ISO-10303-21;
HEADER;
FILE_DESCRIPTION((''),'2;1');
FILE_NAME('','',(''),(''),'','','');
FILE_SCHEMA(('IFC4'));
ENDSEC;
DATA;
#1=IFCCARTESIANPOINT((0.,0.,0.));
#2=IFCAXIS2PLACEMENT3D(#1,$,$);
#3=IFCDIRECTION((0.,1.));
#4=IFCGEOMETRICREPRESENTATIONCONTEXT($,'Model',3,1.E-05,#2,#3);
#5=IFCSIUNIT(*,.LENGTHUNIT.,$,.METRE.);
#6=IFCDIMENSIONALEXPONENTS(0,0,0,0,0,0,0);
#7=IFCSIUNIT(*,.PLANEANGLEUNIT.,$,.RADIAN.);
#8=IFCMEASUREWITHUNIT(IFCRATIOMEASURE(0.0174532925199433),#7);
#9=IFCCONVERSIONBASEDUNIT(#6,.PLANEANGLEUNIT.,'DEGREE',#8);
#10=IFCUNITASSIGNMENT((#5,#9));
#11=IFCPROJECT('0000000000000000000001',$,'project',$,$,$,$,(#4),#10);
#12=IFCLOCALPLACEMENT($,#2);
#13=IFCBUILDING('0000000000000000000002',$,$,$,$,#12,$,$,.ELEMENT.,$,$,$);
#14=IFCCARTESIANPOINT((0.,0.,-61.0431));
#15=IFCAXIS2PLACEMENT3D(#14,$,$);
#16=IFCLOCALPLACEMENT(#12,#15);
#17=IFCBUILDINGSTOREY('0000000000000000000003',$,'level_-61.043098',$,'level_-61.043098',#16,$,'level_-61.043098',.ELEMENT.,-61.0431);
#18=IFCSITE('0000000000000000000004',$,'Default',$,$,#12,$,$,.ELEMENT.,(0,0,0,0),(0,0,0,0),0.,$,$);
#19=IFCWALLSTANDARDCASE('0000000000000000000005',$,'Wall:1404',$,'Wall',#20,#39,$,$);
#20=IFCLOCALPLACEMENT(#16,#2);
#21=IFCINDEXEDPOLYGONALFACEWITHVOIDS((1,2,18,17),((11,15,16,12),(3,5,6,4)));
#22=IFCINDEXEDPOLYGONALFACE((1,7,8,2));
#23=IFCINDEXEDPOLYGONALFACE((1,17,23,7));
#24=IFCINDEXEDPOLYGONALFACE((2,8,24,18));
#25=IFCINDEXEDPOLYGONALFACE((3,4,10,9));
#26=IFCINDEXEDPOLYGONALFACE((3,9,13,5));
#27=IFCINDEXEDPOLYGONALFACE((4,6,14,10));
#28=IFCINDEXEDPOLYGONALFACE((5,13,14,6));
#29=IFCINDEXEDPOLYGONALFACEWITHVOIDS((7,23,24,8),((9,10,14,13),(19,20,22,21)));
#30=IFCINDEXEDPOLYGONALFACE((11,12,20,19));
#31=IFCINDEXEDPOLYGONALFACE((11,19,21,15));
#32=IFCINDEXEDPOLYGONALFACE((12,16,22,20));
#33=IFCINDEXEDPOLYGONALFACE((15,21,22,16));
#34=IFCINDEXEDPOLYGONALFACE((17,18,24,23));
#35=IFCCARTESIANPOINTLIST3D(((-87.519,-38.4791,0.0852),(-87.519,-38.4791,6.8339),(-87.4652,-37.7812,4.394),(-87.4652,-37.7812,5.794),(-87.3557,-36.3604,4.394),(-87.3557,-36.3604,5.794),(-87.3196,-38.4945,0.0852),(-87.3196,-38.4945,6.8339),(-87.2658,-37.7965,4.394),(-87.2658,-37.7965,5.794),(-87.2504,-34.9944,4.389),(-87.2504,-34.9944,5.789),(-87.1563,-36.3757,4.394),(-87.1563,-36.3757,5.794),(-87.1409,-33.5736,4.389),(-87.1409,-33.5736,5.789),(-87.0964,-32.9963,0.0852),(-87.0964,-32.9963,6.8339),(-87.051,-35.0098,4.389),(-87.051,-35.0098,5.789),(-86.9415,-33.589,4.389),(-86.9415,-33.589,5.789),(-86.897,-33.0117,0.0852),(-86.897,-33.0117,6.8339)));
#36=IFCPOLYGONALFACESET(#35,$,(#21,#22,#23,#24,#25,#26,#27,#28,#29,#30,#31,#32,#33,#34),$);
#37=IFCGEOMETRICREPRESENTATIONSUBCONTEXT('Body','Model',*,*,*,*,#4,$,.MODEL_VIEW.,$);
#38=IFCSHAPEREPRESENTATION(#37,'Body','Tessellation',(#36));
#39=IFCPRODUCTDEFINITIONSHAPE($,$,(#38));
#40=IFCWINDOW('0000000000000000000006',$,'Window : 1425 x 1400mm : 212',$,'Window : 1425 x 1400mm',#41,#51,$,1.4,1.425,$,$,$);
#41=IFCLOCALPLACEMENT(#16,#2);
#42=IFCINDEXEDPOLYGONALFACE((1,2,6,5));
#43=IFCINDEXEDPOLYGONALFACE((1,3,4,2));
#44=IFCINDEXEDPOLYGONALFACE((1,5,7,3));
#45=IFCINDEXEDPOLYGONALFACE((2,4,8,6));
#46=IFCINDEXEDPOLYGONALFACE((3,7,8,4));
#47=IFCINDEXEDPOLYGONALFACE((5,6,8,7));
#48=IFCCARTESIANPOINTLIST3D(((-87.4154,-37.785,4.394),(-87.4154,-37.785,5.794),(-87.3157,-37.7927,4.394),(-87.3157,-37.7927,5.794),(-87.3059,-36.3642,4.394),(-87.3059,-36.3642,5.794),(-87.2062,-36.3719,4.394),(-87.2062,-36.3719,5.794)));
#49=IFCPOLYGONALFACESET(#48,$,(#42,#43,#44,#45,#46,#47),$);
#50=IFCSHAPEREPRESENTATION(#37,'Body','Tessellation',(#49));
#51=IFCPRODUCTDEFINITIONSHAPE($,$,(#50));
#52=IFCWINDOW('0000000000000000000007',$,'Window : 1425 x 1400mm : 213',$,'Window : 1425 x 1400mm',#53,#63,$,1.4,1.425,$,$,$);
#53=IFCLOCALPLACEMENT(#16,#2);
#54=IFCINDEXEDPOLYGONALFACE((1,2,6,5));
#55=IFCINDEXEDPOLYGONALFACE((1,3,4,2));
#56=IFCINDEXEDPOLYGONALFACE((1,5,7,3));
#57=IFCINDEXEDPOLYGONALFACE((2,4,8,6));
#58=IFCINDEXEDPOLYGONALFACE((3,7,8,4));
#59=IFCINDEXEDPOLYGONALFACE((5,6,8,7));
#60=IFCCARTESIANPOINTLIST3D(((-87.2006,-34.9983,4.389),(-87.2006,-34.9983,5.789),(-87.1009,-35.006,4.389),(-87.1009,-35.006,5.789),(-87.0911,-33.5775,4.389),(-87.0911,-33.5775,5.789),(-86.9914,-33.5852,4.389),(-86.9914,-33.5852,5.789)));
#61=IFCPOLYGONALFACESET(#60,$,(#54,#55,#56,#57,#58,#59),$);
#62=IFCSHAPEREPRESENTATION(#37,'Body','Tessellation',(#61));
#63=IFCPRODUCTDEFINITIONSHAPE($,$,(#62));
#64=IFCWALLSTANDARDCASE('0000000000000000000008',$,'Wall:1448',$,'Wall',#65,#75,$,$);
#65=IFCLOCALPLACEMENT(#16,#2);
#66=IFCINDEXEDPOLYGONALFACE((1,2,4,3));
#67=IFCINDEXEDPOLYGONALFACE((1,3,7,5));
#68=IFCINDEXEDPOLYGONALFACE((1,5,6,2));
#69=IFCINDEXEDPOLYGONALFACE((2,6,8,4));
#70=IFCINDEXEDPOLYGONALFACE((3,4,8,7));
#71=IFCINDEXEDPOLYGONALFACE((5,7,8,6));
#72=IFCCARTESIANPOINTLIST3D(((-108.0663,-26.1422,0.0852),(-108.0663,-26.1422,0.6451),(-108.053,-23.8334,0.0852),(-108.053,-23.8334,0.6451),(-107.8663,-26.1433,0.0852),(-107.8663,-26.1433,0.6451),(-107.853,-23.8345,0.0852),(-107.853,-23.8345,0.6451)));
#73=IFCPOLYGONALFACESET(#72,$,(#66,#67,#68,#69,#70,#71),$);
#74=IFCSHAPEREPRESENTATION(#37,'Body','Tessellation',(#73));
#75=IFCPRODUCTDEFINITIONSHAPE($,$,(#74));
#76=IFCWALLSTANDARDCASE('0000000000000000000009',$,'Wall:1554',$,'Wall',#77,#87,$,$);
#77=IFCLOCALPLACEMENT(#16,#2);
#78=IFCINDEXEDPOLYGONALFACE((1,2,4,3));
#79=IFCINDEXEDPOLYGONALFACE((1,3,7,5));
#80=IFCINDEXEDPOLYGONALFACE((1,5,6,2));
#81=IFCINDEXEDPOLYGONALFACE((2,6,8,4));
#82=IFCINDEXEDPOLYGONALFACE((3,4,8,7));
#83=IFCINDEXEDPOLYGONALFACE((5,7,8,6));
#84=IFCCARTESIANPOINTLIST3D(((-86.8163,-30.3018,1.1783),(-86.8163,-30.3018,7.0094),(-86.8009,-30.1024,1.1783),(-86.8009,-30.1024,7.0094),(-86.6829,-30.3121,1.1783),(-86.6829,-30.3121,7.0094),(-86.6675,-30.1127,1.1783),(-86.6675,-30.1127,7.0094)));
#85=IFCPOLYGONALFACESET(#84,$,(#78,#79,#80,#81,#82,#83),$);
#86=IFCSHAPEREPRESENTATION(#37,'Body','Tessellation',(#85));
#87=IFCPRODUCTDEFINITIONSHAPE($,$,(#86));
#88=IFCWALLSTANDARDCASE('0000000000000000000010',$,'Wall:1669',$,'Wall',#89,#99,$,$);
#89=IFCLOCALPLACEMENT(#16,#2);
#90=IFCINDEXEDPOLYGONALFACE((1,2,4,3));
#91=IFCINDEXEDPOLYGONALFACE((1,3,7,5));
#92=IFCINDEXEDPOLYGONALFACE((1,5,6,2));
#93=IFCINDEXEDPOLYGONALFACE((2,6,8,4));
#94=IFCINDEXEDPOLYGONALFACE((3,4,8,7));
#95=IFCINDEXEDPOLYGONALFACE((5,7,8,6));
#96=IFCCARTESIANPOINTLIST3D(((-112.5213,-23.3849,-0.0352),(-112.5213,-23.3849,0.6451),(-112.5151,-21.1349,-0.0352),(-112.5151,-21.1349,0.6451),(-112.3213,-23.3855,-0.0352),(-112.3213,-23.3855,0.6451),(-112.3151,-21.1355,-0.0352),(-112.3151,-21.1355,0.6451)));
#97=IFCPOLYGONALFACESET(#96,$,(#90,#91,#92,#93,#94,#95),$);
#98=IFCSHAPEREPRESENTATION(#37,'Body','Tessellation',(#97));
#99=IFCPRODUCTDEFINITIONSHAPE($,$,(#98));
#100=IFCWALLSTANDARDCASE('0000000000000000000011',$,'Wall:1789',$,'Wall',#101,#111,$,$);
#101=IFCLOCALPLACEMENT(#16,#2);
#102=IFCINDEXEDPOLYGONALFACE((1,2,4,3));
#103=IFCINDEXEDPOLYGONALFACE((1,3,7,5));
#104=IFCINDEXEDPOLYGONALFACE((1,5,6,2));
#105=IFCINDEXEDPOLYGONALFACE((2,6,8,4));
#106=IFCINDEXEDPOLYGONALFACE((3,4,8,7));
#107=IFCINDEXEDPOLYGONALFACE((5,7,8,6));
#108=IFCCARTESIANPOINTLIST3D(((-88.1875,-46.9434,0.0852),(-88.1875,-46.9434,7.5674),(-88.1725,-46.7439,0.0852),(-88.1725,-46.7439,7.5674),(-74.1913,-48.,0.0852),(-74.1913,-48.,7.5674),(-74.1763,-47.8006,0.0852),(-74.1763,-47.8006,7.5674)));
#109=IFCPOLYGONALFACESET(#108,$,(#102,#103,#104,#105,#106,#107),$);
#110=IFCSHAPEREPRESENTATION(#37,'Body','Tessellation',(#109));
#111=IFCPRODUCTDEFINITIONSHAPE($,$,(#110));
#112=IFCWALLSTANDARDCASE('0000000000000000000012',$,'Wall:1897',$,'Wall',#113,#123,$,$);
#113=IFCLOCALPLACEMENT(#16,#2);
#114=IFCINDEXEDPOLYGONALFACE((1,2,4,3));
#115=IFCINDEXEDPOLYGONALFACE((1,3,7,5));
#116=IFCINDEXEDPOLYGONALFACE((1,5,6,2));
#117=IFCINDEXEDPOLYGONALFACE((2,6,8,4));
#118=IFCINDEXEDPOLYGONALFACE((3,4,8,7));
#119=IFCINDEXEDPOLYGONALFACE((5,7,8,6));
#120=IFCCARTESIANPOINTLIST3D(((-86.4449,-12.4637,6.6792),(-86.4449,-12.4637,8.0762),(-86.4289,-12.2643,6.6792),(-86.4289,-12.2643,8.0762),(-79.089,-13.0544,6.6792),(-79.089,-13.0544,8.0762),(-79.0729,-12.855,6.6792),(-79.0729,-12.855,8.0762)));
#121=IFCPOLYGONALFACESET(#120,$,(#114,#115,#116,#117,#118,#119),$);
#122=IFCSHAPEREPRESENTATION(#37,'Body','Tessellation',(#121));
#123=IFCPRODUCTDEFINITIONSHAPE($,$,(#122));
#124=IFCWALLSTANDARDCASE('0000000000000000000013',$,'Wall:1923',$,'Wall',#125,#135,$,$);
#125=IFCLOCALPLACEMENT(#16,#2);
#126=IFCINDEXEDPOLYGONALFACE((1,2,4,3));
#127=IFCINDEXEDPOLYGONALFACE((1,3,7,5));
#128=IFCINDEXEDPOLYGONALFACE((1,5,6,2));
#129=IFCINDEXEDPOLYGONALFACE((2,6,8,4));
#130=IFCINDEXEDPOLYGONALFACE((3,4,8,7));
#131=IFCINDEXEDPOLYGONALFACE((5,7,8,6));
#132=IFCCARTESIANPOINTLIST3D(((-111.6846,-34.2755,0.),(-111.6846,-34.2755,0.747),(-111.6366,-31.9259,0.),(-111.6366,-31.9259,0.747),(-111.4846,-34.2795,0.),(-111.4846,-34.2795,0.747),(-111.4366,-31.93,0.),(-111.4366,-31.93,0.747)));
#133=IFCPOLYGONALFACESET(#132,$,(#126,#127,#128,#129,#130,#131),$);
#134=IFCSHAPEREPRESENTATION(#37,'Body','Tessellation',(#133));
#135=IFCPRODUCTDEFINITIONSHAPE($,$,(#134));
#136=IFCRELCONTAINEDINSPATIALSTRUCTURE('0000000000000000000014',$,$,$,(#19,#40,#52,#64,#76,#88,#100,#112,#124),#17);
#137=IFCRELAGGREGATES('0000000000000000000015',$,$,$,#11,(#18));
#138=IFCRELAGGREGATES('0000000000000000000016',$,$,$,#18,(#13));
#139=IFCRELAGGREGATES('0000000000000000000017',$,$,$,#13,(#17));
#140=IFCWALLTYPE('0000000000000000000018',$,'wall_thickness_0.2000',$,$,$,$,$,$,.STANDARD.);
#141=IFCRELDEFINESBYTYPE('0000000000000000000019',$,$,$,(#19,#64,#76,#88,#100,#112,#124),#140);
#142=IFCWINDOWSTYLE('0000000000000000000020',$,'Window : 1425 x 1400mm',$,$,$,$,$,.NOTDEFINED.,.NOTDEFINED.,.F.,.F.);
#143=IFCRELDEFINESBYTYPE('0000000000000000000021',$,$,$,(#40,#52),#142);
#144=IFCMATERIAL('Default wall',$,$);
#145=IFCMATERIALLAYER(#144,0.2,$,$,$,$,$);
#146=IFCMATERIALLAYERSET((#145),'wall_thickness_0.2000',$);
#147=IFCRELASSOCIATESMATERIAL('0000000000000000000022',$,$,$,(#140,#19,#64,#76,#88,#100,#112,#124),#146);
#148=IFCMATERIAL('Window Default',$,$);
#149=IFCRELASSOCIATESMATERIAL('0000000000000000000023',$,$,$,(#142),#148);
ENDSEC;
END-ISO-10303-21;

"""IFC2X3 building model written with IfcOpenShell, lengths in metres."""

from ifc_helpers import new_model, entity, si_unit, converted_unit, direction, frame, frame_2d, origin, origin_2d_with_axis, place, context, subcontext, project, spatial, polyline, rectangle, outline, extrude, source, transform, mapped, material, layer, layer_set, layer_usage, type_object, type_shapes, element, fill, save


model = new_model("IFC2X3")

# Units and contexts
model_context = context("Model", 3, precision=1e-05, world=origin(), true_north=direction((0.0, 1.0)))
body_context = subcontext(model_context, "Body", "Model", "MODEL_VIEW")
ifc_project = project(units=[si_unit("LENGTHUNIT", "METRE"), converted_unit("PLANEANGLEUNIT", "DEGREE", entity("IfcRatioMeasure", 0.0174532925199433), si_unit("PLANEANGLEUNIT", "RADIAN"), dimensions=[0, 0, 0, 0, 0, 0, 0])], contexts=[model_context])

# Site, building, storey
placement_1 = place(None, origin())
site = spatial("IfcSite", under=ifc_project, at=placement_1, Name="Default", CompositionType="ELEMENT", RefLatitude=(0, 0, 0, 0), RefLongitude=(0, 0, 0, 0), RefElevation=0.0)
building = spatial("IfcBuilding", under=site, at=placement_1, CompositionType="ELEMENT")
storey_placement = place(placement_1, frame((0.0, 0.0, -61.0431)))
storey = spatial("IfcBuildingStorey", under=building, at=storey_placement, Name="level_-61.043098", ObjectType="level_-61.043098", LongName="level_-61.043098", CompositionType="ELEMENT", Elevation=-61.0431)

# Shared definitions
ifc_material_1 = material(Name="Default wall")
ifc_layer = layer(ifc_material_1, 0.2)
ifc_layer_set = layer_set([ifc_layer], Name="wall_thickness_0.2000")
ifc_layer_usage = layer_usage(ifc_layer_set, "AXIS2", "POSITIVE", -0.1)
wall_type = type_object("IfcWallType", Name="wall_thickness_0.2000", PredefinedType="STANDARD", material=ifc_layer_set)

# Shared definitions
ifc_material_2 = material(Name="Window Default")

# Wall, openings, windows
placement_2 = place(placement_1, frame((0.0, 0.0, -60.9579)))
wall_1_placement = place(placement_2, frame((-86.9967, -33.004, 0.0), z_axis=(0.0, 0.0, 1.0), x_axis=(-0.076848, -0.997043, 0.0)))
wall_1 = element("IfcWallStandardCase", 1, at=wall_1_placement, inside=storey, type_object=wall_type, material=ifc_layer_usage, Name="Wall:1404", ObjectType="Wall", context=body_context, shape_type="SweptSolid", body=[
    extrude(outline(polyline([(5.499, -0.1), (5.499, 0.1), (0.0, 0.1), (0.0, -0.1), (5.499, -0.1)])), origin(), (0.0, 0.0, 1.0), 6.7487),
])
opening_1_placement = place(wall_1_placement, frame((3.374, -0.1, 4.3088)))
opening_1 = element("IfcOpeningElement", 2, at=opening_1_placement, cuts=wall_1, ObjectType="Opening", context=body_context, shape_type="SweptSolid", body=[
    extrude(rectangle(XDim=1.425, YDim=1.4, at=frame_2d((0.7, 0.7125), x_axis=(0.0, 1.0))), frame((0.0, 0.0, 0.0), z_axis=(0.0, 1.0, 0.0), x_axis=(0.0, 0.0, 1.0)), (0.0, 0.0, 1.0), 0.2),
])
opening_2_placement = place(wall_1_placement, frame((0.579, -0.1, 4.3038)))
opening_2 = element("IfcOpeningElement", 3, at=opening_2_placement, cuts=wall_1, ObjectType="Opening", context=body_context, shape_type="SweptSolid", body=[
    extrude(rectangle(XDim=1.425, YDim=1.4, at=frame_2d((0.7, 0.7125), x_axis=(0.0, 1.0))), frame((0.0, 0.0, 0.0), z_axis=(0.0, 1.0, 0.0), x_axis=(0.0, 0.0, 1.0)), (0.0, 0.0, 1.0), 0.2),
])
window_style_1 = type_object("IfcWindowStyle", Name="Window : 1425 x 1400mm", ConstructionType="NOTDEFINED", OperationType="NOTDEFINED", ParameterTakesPrecedence=False, Sizeable=False, material=ifc_material_2)
shared_shape_1 = source(origin(), body_context, "Body", "SweptSolid", [
    extrude(rectangle(XDim=0.1, YDim=1.425, at=origin_2d_with_axis()), frame((0.7125, 0.1, 0.0), z_axis=(0.0, 0.0, 1.0), x_axis=(0.0, 1.0, 0.0)), (0.0, 0.0, 1.0), 1.4),
])
type_shapes(window_style_1, [shared_shape_1])
window_1_placement = place(opening_1_placement, origin())
window_1 = element("IfcWindow", 4, at=window_1_placement, inside=storey, type_object=window_style_1, Name="Window : 1425 x 1400mm : 212", ObjectType="Window : 1425 x 1400mm", OverallHeight=1.4, OverallWidth=1.425, context=body_context, shape_type="MappedRepresentation", body=[
    mapped(shared_shape_1, transform((0.0, 0.0, 0.0), scale=1.0)),
])
fill(opening_1, window_1)
window_2_placement = place(opening_2_placement, origin())
window_2 = element("IfcWindow", 5, at=window_2_placement, inside=storey, type_object=window_style_1, Name="Window : 1425 x 1400mm : 213", ObjectType="Window : 1425 x 1400mm", OverallHeight=1.4, OverallWidth=1.425, context=body_context, shape_type="MappedRepresentation", body=[
    mapped(shared_shape_1, transform((0.0, 0.0, 0.0), scale=1.0)),
])
fill(opening_2, window_2)

# Walls
placement_3 = place(placement_1, frame((0.0, 0.0, -60.9579)))
wall_2_placement = place(placement_3, frame((-107.9663, -26.1428, 0.0), z_axis=(0.0, 0.0, 1.0), x_axis=(0.00574, 0.999984, 0.0)))
element("IfcWallStandardCase", 6, at=wall_2_placement, inside=storey, type_object=wall_type, material=ifc_layer_usage, Name="Wall:1448", ObjectType="Wall", context=body_context, shape_type="SweptSolid", body=[
    extrude(outline(polyline([(2.3089, -0.1), (2.3089, 0.1), (0.0, 0.1), (0.0, -0.1), (2.3089, -0.1)])), origin(), (0.0, 0.0, 1.0), 0.5598),
])
placement_4 = place(placement_1, frame((0.0, 0.0, -59.8648)))
wall_3_placement = place(placement_4, frame((-86.6752, -30.2124, 0.0), z_axis=(0.0, 0.0, 1.0), x_axis=(-0.997056, 0.076673, 0.0)))
element("IfcWallStandardCase", 7, at=wall_3_placement, inside=storey, type_object=wall_type, material=ifc_layer_usage, Name="Wall:1554", ObjectType="Wall", context=body_context, shape_type="SweptSolid", body=[
    extrude(outline(polyline([(0.1338, -0.1), (0.1338, 0.1), (0.0, 0.1), (0.0, -0.1), (0.1338, -0.1)])), origin(), (0.0, 0.0, 1.0), 5.831),
])
placement_5 = place(placement_1, frame((0.0, 0.0, -61.0783)))
wall_4_placement = place(placement_5, frame((-112.4151, -21.1352, 0.0), z_axis=(0.0, 0.0, 1.0), x_axis=(-0.002743, -0.999996, 0.0)))
element("IfcWallStandardCase", 8, at=wall_4_placement, inside=storey, type_object=wall_type, material=ifc_layer_usage, Name="Wall:1669", ObjectType="Wall", context=body_context, shape_type="SweptSolid", body=[
    extrude(outline(polyline([(2.25, -0.1), (2.25, 0.1), (0.0, 0.1), (0.0, -0.1), (2.25, -0.1)])), origin(), (0.0, 0.0, 1.0), 0.6803),
])
placement_6 = place(placement_1, frame((0.0, 0.0, -60.9579)))
wall_5_placement = place(placement_6, frame((-88.18, -46.8437, 0.0), z_axis=(0.0, 0.0, 1.0), x_axis=(0.997162, -0.075282, 0.0)))
element("IfcWallStandardCase", 9, at=wall_5_placement, inside=storey, type_object=wall_type, material=ifc_layer_usage, Name="Wall:1789", ObjectType="Wall", context=body_context, shape_type="SweptSolid", body=[
    extrude(outline(polyline([(14.036, -0.1), (14.036, 0.1), (0.0, 0.1), (0.0, -0.1), (14.036, -0.1)])), origin(), (0.0, 0.0, 1.0), 7.4822),
])
placement_7 = place(placement_1, frame((0.0, 0.0, -54.3639)))
wall_6_placement = place(placement_7, frame((-86.4369, -12.364, 0.0), z_axis=(0.0, 0.0, 1.0), x_axis=(0.996791, -0.080044, 0.0)))
element("IfcWallStandardCase", 10, at=wall_6_placement, inside=storey, type_object=wall_type, material=ifc_layer_usage, Name="Wall:1897", ObjectType="Wall", context=body_context, shape_type="SweptSolid", body=[
    extrude(outline(polyline([(7.3797, -0.1), (7.3797, 0.1), (0.0, 0.1), (0.0, -0.1), (7.3797, -0.1)])), origin(), (0.0, 0.0, 1.0), 1.397),
])
wall_7_placement = place(storey_placement, frame((-111.5366, -31.928, 0.0), z_axis=(0.0, 0.0, 1.0), x_axis=(-0.020427, -0.999791, 0.0)))
element("IfcWallStandardCase", 11, at=wall_7_placement, inside=storey, type_object=wall_type, material=ifc_layer_usage, Name="Wall:1923", ObjectType="Wall", context=body_context, shape_type="SweptSolid", body=[
    extrude(outline(polyline([(2.35, -0.1), (2.35, 0.1), (0.0, 0.1), (0.0, -0.1), (2.35, -0.1)])), origin(), (0.0, 0.0, 1.0), 0.747),
])

save(model, "model.ifc")
